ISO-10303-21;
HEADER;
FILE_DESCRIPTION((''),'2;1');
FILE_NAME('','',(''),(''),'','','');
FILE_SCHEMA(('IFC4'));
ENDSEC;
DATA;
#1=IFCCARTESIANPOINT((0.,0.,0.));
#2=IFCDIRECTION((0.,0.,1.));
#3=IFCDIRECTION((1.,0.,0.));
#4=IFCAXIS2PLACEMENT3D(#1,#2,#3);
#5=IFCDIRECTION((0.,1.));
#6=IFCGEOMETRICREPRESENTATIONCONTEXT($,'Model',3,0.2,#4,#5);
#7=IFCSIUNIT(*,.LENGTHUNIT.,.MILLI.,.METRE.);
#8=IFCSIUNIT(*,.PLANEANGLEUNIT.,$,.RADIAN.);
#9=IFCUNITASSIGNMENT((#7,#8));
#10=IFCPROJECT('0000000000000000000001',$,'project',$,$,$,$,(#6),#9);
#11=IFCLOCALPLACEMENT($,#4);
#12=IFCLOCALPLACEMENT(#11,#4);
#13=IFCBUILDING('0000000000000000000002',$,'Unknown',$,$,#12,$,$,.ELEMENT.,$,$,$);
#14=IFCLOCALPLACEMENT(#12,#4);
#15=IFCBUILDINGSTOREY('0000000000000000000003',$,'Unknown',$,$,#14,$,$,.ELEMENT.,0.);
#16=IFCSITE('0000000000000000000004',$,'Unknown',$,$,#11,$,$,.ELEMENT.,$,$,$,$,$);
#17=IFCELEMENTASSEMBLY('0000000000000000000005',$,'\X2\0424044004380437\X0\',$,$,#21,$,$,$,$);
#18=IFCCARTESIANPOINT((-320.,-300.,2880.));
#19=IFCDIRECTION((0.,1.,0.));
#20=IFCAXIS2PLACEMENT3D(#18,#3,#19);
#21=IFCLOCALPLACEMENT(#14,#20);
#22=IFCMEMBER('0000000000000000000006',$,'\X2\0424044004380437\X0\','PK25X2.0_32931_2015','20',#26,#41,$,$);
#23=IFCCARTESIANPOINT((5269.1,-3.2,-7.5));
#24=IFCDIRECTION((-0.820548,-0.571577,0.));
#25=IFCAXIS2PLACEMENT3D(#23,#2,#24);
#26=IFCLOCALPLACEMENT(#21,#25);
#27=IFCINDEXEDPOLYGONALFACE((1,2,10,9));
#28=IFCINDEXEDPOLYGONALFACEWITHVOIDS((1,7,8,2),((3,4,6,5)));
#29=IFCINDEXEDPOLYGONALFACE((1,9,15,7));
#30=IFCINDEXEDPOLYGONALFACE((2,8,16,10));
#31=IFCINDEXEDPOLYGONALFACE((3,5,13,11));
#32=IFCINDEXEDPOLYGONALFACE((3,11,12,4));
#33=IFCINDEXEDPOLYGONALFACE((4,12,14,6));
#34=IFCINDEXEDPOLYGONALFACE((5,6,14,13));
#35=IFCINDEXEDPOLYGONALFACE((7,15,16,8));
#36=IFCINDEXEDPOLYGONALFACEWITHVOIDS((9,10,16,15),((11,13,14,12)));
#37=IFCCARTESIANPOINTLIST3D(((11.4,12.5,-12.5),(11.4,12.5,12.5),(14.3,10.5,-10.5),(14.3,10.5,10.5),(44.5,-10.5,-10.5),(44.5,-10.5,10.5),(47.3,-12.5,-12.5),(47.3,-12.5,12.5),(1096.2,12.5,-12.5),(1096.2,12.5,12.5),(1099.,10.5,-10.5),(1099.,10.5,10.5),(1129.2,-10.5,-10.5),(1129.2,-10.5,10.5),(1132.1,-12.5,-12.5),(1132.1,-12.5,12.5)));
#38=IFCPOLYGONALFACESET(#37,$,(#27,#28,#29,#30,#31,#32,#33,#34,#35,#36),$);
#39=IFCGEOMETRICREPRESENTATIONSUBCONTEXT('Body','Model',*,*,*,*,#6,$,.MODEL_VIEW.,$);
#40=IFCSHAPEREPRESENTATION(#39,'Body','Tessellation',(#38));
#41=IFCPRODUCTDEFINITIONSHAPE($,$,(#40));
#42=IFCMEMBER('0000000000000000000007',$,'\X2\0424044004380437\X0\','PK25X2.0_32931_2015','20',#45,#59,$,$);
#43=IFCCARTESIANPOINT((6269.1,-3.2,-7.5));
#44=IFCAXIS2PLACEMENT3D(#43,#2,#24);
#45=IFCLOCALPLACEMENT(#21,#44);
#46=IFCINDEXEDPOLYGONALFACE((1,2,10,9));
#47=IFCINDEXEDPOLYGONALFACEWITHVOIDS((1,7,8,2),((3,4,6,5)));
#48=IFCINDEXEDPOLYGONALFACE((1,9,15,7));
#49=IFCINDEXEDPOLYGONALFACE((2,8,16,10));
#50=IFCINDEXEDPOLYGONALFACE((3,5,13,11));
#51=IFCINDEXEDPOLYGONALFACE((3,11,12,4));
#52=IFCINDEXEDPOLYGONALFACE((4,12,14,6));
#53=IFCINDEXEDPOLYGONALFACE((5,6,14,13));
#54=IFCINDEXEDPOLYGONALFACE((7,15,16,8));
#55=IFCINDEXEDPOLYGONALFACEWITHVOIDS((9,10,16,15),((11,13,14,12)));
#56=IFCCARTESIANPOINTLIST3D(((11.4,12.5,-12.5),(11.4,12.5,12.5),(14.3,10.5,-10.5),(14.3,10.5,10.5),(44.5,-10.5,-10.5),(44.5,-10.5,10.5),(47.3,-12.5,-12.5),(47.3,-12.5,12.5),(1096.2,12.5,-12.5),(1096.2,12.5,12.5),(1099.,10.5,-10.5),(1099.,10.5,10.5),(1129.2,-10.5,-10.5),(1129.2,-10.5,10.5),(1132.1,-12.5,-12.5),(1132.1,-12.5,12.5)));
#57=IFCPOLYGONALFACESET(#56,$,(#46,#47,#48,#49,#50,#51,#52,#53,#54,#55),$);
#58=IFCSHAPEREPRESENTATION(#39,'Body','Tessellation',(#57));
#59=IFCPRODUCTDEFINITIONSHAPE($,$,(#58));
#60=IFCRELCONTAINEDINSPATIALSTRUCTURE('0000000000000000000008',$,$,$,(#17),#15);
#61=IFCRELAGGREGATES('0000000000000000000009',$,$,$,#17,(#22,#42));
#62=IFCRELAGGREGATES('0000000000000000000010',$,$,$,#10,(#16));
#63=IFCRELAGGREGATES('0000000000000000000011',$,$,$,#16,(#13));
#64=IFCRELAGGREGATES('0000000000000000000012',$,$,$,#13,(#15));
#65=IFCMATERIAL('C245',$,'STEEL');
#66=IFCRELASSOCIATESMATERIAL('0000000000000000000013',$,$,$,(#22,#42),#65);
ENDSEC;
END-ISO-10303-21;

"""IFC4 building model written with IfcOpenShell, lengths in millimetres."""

from ifc_helpers import new_model, si_unit, direction, frame, origin_with_axes, place, context, subcontext, project, spatial, line, indexed_curve, outline, extrude, material, element, aggregate, save


model = new_model("IFC4")

# Units and contexts
model_context = context("Model", 3, precision=0.2, world=origin_with_axes(), true_north=direction((0.0, 1.0)))
body_context = subcontext(model_context, "Body", "Model", "MODEL_VIEW")
ifc_project = project(units=[si_unit("LENGTHUNIT", "METRE", prefix="MILLI"), si_unit("PLANEANGLEUNIT", "RADIAN")], contexts=[model_context])

# Site, building, storey
site_placement = place(None, origin_with_axes())
site = spatial("IfcSite", under=ifc_project, at=site_placement, Name="Unknown", CompositionType="ELEMENT")
building_placement = place(site_placement, origin_with_axes())
building = spatial("IfcBuilding", under=site, at=building_placement, Name="Unknown", CompositionType="ELEMENT")
storey_placement = place(building_placement, origin_with_axes())
storey = spatial("IfcBuildingStorey", under=building, at=storey_placement, Name="Unknown", CompositionType="ELEMENT", Elevation=0.0)

# Shared definitions
ifc_material_1 = material(Name="C245", Category="STEEL")

# Element assembly, members, voiding features
assembly_1_placement = place(storey_placement, frame((-320.0, -300.0, 2880.0), z_axis=(1.0, 0.0, 0.0), x_axis=(0.0, 1.0, 0.0)))
assembly_1 = element("IfcElementAssembly", 1, at=assembly_1_placement, inside=storey, Name="Фриз")
member_1_placement = place(assembly_1_placement, frame((5269.1, -3.2, -7.5), z_axis=(0.0, 0.0, 1.0), x_axis=(-0.820548, -0.571577, 0.0)))
member_1 = element("IfcMember", 2, at=member_1_placement, material=ifc_material_1, Name="Фриз", Description="PK25X2.0_32931_2015", ObjectType="20", context=body_context, shape_type="SolidModel", body=[
    extrude(outline(indexed_curve([(-12.5, -12.5), (12.5, -12.5), (12.5, 12.5), (-12.5, 12.5)], segments=[line(1, 2, 3, 4, 1)]), holes=[indexed_curve([(-10.5, -10.5), (-10.5, 10.5), (10.5, 10.5), (10.5, -10.5)], segments=[line(1, 2, 3, 4, 1)])]), frame((0.0, 0.0, 0.0), z_axis=(-1.0, 0.0, 0.0), x_axis=(0.0, 0.0, 1.0)), (0.0, 0.0, -1.0), 1143.5),
])
voiding_feature_1_placement = place(member_1_placement, frame((899.1, -630.2, 7.5), z_axis=(0.0, 0.0, 1.0), x_axis=(-0.820548, 0.571577, 0.0)))
element("IfcVoidingFeature", 3, at=voiding_feature_1_placement, cuts=member_1, Name="CUT_BEAM", ObjectType="(?)", PredefinedType="HOLE", context=body_context, shape_type="SolidModel", body=[
    extrude(outline(indexed_curve([(-20.0, -20.0), (20.0, -20.0), (20.0, 20.0), (-20.0, 20.0)], segments=[line(1, 2, 3, 4, 1)])), frame((0.0, 0.0, 0.0), z_axis=(-1.0, 0.0, 0.0), x_axis=(0.0, 0.0, 1.0)), (0.0, 0.0, -1.0), 2205.1),
])
voiding_feature_2_placement = place(member_1_placement, frame((2053.8, -630.2, 7.5), z_axis=(0.0, 0.0, 1.0), x_axis=(-0.820548, 0.571577, 0.0)))
element("IfcVoidingFeature", 4, at=voiding_feature_2_placement, cuts=member_1, Name="CUT_BEAM", ObjectType="(?)", PredefinedType="HOLE", context=body_context, shape_type="SolidModel", body=[
    extrude(outline(indexed_curve([(-20.0, -20.0), (20.0, -20.0), (20.0, 20.0), (-20.0, 20.0)], segments=[line(1, 2, 3, 4, 1)])), frame((0.0, 0.0, 0.0), z_axis=(-1.0, 0.0, 0.0), x_axis=(0.0, 0.0, 1.0)), (0.0, 0.0, -1.0), 2205.1),
])
member_2_placement = place(assembly_1_placement, frame((6269.1, -3.2, -7.5), z_axis=(0.0, 0.0, 1.0), x_axis=(-0.820548, -0.571577, 0.0)))
member_2 = element("IfcMember", 5, at=member_2_placement, material=ifc_material_1, Name="Фриз", Description="PK25X2.0_32931_2015", ObjectType="20", context=body_context, shape_type="SolidModel", body=[
    extrude(outline(indexed_curve([(-12.5, -12.5), (12.5, -12.5), (12.5, 12.5), (-12.5, 12.5)], segments=[line(1, 2, 3, 4, 1)]), holes=[indexed_curve([(-10.5, -10.5), (-10.5, 10.5), (10.5, 10.5), (10.5, -10.5)], segments=[line(1, 2, 3, 4, 1)])]), frame((0.0, 0.0, 0.0), z_axis=(-1.0, 0.0, 0.0), x_axis=(0.0, 0.0, 1.0)), (0.0, 0.0, -1.0), 1143.5),
])
voiding_feature_3_placement = place(member_2_placement, frame((899.1, -630.2, 7.5), z_axis=(0.0, 0.0, 1.0), x_axis=(-0.820548, 0.571577, 0.0)))
element("IfcVoidingFeature", 6, at=voiding_feature_3_placement, cuts=member_2, Name="CUT_BEAM", ObjectType="(?)", PredefinedType="HOLE", context=body_context, shape_type="SolidModel", body=[
    extrude(outline(indexed_curve([(-20.0, -20.0), (20.0, -20.0), (20.0, 20.0), (-20.0, 20.0)], segments=[line(1, 2, 3, 4, 1)])), frame((0.0, 0.0, 0.0), z_axis=(-1.0, 0.0, 0.0), x_axis=(0.0, 0.0, 1.0)), (0.0, 0.0, -1.0), 2205.1),
])
voiding_feature_4_placement = place(member_2_placement, frame((2053.8, -630.2, 7.5), z_axis=(0.0, 0.0, 1.0), x_axis=(-0.820548, 0.571577, 0.0)))
element("IfcVoidingFeature", 7, at=voiding_feature_4_placement, cuts=member_2, Name="CUT_BEAM", ObjectType="(?)", PredefinedType="HOLE", context=body_context, shape_type="SolidModel", body=[
    extrude(outline(indexed_curve([(-20.0, -20.0), (20.0, -20.0), (20.0, 20.0), (-20.0, 20.0)], segments=[line(1, 2, 3, 4, 1)])), frame((0.0, 0.0, 0.0), z_axis=(-1.0, 0.0, 0.0), x_axis=(0.0, 0.0, 1.0)), (0.0, 0.0, -1.0), 2205.1),
])
aggregate(assembly_1, [member_1, member_2])

save(model, "model.ifc")
